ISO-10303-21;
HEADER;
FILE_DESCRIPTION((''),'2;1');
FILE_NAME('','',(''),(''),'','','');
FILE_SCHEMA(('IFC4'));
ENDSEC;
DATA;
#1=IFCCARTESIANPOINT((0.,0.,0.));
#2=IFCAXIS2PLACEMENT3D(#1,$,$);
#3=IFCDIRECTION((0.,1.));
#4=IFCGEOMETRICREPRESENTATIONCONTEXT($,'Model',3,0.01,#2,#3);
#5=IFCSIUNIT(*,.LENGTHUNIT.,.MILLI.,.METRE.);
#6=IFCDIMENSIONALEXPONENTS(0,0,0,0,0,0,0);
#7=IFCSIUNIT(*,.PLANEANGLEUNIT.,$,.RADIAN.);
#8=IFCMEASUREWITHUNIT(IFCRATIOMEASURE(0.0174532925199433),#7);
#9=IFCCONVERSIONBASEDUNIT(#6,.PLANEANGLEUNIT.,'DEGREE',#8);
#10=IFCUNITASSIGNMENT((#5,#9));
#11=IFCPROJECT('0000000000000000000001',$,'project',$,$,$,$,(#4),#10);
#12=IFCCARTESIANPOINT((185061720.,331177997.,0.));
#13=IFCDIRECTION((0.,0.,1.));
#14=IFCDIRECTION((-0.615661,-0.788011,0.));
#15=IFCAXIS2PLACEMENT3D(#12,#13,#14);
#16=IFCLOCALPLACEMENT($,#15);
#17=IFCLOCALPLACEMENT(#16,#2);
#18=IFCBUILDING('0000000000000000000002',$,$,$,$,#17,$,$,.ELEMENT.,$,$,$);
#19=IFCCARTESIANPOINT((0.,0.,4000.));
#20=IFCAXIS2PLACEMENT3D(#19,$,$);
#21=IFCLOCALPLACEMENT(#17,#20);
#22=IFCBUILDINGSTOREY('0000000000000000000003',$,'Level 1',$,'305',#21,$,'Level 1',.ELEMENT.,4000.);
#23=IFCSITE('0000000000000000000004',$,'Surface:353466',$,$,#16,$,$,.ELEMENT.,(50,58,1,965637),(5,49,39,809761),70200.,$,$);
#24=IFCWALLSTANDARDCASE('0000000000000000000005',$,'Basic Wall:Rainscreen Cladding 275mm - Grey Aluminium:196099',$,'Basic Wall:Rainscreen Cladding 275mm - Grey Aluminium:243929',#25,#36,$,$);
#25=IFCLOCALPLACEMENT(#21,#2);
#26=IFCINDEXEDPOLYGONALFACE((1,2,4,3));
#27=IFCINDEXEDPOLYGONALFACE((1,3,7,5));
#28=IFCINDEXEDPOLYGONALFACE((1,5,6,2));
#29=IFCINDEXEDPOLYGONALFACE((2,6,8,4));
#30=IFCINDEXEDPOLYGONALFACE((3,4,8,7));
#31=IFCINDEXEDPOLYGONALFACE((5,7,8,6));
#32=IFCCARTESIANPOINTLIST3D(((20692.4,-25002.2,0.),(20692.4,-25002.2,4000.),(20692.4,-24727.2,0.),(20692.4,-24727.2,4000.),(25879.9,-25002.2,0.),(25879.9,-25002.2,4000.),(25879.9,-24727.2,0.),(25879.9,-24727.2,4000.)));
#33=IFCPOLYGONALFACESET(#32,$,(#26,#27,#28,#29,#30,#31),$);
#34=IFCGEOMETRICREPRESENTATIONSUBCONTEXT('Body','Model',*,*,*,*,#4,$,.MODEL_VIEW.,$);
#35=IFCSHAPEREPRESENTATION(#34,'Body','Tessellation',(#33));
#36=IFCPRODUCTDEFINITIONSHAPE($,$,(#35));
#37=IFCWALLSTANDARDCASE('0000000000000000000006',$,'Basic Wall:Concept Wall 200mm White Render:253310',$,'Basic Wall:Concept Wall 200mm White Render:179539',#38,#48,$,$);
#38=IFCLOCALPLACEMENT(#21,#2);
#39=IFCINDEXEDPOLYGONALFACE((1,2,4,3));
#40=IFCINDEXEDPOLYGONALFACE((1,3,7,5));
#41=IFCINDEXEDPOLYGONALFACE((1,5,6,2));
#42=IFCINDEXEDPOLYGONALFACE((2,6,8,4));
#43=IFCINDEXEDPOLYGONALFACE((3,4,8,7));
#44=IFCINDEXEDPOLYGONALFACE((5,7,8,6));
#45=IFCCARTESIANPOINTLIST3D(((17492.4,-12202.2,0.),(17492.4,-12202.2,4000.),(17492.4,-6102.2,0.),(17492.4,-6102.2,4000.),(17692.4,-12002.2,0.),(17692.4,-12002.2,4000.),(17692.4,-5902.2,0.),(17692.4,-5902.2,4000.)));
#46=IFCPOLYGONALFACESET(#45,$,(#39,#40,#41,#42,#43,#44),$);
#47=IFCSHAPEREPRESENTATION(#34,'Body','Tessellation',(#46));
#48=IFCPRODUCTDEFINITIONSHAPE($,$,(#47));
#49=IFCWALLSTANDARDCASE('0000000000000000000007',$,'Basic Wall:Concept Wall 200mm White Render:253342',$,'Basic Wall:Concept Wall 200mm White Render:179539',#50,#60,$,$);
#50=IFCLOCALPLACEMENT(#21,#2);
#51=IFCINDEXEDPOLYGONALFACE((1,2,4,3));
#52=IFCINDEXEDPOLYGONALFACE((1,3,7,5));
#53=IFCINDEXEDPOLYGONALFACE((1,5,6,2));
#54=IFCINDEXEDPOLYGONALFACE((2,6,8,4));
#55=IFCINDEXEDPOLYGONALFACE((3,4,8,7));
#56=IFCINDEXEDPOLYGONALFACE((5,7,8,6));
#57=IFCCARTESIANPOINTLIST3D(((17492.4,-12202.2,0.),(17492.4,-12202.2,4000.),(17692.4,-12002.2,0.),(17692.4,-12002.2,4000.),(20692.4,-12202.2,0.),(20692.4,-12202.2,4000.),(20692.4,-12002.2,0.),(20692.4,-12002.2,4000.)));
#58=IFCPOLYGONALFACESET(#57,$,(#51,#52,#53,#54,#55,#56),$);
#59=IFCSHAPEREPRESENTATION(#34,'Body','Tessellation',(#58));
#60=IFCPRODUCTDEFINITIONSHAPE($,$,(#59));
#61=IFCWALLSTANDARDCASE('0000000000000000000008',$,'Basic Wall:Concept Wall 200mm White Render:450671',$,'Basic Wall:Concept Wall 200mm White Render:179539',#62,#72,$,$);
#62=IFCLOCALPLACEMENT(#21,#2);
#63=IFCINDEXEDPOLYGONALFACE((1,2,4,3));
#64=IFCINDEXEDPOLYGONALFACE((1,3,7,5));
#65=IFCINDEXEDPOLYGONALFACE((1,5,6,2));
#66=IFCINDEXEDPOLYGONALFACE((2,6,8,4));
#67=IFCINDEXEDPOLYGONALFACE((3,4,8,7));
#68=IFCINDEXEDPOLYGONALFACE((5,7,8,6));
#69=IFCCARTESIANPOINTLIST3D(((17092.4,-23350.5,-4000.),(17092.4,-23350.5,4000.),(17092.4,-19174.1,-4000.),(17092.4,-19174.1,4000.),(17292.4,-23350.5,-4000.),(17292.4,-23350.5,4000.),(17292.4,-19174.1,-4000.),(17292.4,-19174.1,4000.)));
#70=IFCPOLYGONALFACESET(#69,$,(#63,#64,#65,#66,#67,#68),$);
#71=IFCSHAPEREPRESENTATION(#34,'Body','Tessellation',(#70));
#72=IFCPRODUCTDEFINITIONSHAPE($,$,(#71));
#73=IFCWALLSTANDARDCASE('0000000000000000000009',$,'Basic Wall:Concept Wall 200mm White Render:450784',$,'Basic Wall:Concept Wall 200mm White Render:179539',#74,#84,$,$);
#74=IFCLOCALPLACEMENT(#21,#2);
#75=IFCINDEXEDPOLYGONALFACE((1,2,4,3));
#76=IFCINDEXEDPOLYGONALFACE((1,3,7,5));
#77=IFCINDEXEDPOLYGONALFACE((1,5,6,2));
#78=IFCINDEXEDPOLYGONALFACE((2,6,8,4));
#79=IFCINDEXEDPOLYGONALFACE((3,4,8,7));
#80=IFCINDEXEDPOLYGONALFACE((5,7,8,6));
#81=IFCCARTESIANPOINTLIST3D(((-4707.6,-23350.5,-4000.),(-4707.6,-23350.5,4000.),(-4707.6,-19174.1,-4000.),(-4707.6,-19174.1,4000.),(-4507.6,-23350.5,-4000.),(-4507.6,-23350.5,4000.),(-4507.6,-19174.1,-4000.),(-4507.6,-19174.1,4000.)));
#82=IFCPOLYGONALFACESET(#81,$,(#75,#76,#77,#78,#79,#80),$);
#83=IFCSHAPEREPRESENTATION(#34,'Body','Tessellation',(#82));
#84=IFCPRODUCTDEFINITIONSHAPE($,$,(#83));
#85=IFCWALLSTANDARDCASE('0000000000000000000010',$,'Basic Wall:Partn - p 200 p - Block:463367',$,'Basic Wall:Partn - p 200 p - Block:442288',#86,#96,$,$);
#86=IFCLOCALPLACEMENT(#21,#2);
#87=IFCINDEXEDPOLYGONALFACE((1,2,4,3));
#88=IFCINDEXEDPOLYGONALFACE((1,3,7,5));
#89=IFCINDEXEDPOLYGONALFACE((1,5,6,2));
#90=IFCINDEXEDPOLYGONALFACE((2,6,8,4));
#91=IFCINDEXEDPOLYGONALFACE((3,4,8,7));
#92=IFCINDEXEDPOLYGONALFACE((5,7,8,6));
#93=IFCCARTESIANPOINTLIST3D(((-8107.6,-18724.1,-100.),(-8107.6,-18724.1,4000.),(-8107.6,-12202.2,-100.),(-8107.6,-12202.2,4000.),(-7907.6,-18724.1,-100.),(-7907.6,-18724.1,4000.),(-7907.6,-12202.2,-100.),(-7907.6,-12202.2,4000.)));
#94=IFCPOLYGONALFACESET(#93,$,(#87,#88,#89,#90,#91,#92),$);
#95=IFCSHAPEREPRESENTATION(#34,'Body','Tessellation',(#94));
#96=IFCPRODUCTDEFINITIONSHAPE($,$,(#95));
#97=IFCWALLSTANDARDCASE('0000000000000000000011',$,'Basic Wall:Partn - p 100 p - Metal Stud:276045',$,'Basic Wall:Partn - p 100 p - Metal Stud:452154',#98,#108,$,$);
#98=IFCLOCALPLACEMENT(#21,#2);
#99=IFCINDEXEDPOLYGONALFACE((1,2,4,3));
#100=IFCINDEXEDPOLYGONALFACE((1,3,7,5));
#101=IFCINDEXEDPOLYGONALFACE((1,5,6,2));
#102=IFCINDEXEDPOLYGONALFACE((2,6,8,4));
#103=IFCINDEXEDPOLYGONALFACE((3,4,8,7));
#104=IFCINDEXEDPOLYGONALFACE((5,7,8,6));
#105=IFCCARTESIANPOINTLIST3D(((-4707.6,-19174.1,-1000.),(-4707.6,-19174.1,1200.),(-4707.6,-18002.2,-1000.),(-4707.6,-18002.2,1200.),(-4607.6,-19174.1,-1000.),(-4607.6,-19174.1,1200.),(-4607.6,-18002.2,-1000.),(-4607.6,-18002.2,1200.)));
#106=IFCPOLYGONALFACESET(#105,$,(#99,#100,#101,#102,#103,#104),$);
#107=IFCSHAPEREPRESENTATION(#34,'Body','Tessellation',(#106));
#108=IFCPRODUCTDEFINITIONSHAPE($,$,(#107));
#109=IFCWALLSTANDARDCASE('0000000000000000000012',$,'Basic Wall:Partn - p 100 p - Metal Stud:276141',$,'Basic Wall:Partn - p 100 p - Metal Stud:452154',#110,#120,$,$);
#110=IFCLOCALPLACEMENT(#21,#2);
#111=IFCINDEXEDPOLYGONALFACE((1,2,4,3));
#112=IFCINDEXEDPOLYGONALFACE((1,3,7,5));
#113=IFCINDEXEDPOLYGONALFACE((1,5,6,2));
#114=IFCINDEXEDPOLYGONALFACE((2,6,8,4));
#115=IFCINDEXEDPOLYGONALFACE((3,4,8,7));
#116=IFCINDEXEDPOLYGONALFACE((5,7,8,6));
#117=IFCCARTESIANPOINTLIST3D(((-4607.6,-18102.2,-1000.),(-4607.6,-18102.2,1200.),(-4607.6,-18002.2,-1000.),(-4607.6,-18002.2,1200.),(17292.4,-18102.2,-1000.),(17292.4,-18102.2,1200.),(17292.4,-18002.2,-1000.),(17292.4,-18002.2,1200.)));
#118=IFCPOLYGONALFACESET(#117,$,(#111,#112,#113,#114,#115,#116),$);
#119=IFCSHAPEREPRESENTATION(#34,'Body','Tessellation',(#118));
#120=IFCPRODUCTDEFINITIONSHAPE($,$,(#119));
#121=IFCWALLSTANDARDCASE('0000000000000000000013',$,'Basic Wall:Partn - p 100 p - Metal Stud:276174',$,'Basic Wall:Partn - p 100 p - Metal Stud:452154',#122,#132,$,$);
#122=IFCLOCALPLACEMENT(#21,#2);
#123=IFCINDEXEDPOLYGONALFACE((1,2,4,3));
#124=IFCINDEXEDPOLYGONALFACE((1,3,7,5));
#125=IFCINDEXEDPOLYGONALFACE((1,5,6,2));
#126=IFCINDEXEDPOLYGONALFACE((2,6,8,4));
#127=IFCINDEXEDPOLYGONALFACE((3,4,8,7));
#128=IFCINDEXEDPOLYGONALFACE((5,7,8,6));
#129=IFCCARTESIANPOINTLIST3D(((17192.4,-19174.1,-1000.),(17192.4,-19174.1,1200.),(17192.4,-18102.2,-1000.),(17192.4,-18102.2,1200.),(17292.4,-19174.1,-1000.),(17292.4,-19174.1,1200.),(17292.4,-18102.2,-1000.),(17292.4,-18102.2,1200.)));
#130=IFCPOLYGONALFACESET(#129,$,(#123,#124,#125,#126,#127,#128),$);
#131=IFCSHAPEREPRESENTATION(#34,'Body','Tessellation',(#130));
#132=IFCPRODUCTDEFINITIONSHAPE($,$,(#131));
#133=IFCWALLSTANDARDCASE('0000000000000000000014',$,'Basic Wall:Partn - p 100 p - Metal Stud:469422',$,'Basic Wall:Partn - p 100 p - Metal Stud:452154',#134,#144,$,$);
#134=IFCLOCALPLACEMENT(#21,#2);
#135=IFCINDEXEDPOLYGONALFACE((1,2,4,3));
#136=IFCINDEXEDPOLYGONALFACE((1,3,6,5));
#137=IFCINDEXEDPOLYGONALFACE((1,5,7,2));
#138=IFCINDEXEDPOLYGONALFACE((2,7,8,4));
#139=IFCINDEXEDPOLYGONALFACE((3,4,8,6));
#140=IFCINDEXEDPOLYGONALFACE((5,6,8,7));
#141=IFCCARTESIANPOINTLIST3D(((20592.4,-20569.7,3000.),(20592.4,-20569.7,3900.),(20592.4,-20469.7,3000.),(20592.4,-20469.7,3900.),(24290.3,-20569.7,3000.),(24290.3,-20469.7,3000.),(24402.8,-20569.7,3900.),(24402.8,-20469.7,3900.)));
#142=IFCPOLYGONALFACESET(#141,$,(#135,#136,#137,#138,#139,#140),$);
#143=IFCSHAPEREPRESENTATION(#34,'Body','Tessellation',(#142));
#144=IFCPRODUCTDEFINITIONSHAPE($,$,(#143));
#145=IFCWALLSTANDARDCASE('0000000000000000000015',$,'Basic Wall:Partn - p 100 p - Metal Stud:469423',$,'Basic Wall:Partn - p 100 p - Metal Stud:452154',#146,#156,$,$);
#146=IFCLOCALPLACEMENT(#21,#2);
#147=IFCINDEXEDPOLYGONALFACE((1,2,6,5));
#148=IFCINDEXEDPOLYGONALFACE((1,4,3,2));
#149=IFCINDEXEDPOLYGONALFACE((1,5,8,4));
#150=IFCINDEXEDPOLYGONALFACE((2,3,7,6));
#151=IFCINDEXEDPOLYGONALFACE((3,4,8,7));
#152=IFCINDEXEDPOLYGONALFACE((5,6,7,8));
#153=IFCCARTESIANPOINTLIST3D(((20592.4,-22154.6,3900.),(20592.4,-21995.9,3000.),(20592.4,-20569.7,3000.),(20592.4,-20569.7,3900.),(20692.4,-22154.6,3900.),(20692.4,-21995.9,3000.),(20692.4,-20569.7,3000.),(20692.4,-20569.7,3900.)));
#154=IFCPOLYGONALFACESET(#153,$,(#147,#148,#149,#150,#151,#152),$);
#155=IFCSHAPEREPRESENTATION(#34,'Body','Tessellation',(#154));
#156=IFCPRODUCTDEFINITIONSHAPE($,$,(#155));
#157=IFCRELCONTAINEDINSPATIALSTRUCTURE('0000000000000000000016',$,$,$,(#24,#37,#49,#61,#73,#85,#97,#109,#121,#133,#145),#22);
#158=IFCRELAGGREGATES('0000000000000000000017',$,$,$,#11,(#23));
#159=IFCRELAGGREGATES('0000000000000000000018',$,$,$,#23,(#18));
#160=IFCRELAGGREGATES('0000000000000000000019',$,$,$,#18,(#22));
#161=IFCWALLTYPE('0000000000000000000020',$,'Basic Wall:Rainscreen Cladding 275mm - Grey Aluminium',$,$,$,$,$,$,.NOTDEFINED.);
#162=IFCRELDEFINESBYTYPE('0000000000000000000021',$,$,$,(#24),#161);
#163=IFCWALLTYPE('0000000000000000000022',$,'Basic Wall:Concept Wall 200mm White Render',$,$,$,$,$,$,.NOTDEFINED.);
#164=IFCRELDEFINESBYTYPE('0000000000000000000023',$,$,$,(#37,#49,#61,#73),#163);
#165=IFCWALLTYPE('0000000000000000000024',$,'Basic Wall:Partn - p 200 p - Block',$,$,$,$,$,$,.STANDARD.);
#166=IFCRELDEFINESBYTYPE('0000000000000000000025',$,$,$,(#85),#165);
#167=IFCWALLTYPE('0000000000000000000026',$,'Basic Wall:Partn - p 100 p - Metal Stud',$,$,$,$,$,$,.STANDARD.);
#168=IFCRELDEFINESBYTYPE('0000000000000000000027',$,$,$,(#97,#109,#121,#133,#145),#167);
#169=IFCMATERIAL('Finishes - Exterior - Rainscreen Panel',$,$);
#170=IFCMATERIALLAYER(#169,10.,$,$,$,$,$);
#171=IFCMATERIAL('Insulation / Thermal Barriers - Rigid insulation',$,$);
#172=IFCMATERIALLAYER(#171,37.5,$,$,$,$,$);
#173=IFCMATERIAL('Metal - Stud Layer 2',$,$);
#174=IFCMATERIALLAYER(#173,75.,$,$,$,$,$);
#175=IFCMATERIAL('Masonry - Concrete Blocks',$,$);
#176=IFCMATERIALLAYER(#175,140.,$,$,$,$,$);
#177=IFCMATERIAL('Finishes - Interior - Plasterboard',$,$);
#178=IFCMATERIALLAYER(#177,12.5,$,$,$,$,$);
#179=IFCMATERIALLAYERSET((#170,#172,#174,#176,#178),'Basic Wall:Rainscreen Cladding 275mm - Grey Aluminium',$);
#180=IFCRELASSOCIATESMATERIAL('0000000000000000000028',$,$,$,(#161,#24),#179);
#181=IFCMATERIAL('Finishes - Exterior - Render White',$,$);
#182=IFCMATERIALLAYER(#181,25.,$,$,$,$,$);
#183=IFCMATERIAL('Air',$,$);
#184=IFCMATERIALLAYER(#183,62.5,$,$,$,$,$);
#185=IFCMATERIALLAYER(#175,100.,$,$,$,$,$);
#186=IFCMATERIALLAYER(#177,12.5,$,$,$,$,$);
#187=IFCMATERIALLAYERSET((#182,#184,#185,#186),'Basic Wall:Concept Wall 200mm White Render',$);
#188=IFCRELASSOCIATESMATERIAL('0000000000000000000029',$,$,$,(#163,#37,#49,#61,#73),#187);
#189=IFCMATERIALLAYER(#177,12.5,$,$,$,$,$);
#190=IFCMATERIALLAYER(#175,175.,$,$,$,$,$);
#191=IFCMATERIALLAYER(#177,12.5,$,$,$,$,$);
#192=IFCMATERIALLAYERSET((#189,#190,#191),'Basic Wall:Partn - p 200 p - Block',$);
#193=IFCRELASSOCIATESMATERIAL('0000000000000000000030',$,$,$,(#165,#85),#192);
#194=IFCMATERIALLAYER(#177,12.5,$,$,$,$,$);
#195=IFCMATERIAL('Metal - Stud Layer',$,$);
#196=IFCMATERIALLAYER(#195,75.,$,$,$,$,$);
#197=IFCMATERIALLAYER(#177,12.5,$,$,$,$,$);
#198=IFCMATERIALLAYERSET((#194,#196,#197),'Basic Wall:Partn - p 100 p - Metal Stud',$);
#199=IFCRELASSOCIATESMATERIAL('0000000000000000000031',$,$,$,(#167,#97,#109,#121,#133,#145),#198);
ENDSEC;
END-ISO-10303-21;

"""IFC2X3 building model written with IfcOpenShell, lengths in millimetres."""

from ifc_helpers import new_model, entity, si_unit, converted_unit, direction, frame, frame_2d, origin, place, context, subcontext, project, spatial, polyline, rectangle, outline, extrude, clip, halfspace, material, layer, layer_set, layer_usage, type_object, element, save


model = new_model("IFC2X3")

# Units and contexts
model_context = context("Model", 3, precision=0.01, world=origin(), true_north=direction((0.0, 1.0)))
body_context = subcontext(model_context, "Body", "Model", "MODEL_VIEW")
ifc_project = project(units=[si_unit("LENGTHUNIT", "METRE", prefix="MILLI"), converted_unit("PLANEANGLEUNIT", "DEGREE", entity("IfcRatioMeasure", 0.0174532925199433), si_unit("PLANEANGLEUNIT", "RADIAN"), dimensions=[0, 0, 0, 0, 0, 0, 0])], contexts=[model_context])

# Site, building, storey
site_placement = place(None, frame((185061720.0, 331177997.0, 0.0), z_axis=(0.0, 0.0, 1.0), x_axis=(-0.615661, -0.788011, 0.0)))
site = spatial("IfcSite", under=ifc_project, at=site_placement, Name="Surface:353466", CompositionType="ELEMENT", RefLatitude=(50, 58, 1, 965637), RefLongitude=(5, 49, 39, 809761), RefElevation=70200.0)
building_placement = place(site_placement, origin())
building = spatial("IfcBuilding", under=site, at=building_placement, CompositionType="ELEMENT")
storey_placement = place(building_placement, frame((0.0, 0.0, 4000.0)))
storey = spatial("IfcBuildingStorey", under=building, at=storey_placement, Name="Level 1", ObjectType="305", LongName="Level 1", CompositionType="ELEMENT", Elevation=4000.0)

# Walls
ifc_material_1 = material(Name="Finishes - Exterior - Rainscreen Panel")
ifc_layer_1 = layer(ifc_material_1, 10.0)
ifc_material_2 = material(Name="Insulation / Thermal Barriers - Rigid insulation")
ifc_layer_2 = layer(ifc_material_2, 37.5)
ifc_material_3 = material(Name="Metal - Stud Layer 2")
ifc_layer_3 = layer(ifc_material_3, 75.0)
ifc_material_4 = material(Name="Masonry - Concrete Blocks")
ifc_layer_4 = layer(ifc_material_4, 140.0)
ifc_material_5 = material(Name="Finishes - Interior - Plasterboard")
ifc_layer_5 = layer(ifc_material_5, 12.5)
ifc_layer_set_1 = layer_set([ifc_layer_1, ifc_layer_2, ifc_layer_3, ifc_layer_4, ifc_layer_5], Name="Basic Wall:Rainscreen Cladding 275mm - Grey Aluminium")
ifc_layer_usage_1 = layer_usage(ifc_layer_set_1, "AXIS2", "POSITIVE", -137.5)
wall_type_1 = type_object("IfcWallType", Name="Basic Wall:Rainscreen Cladding 275mm - Grey Aluminium", PredefinedType="NOTDEFINED", material=ifc_layer_set_1)
wall_1_placement = place(storey_placement, frame((20692.4, -24864.7, 0.0)))
element("IfcWallStandardCase", 1, at=wall_1_placement, inside=storey, type_object=wall_type_1, material=ifc_layer_usage_1, Name="Basic Wall:Rainscreen Cladding 275mm - Grey Aluminium:196099", ObjectType="Basic Wall:Rainscreen Cladding 275mm - Grey Aluminium:243929", context=body_context, shape_type="Clipping", body=[
    clip(extrude(rectangle(XDim=5187.5, YDim=275.0, at=frame_2d((2593.8, 0.0), x_axis=(-1.0, 0.0))), origin(), (0.0, 0.0, 1.0), 4000.0), halfspace(frame((0.0, 0.0, -4000.0)), True)),
])
ifc_material_6 = material(Name="Finishes - Exterior - Render White")
ifc_layer_6 = layer(ifc_material_6, 25.0)
ifc_material_7 = material(Name="Air")
ifc_layer_7 = layer(ifc_material_7, 62.5)
ifc_layer_8 = layer(ifc_material_4, 100.0)
ifc_layer_9 = layer(ifc_material_5, 12.5)
ifc_layer_set_2 = layer_set([ifc_layer_6, ifc_layer_7, ifc_layer_8, ifc_layer_9], Name="Basic Wall:Concept Wall 200mm White Render")
ifc_layer_usage_2 = layer_usage(ifc_layer_set_2, "AXIS2", "NEGATIVE", 100.0)
wall_type_2 = type_object("IfcWallType", Name="Basic Wall:Concept Wall 200mm White Render", PredefinedType="NOTDEFINED", material=ifc_layer_set_2)
wall_2_placement = place(storey_placement, frame((17592.4, -5902.2, 0.0), z_axis=(0.0, 0.0, 1.0), x_axis=(0.0, -1.0, 0.0)))
element("IfcWallStandardCase", 2, at=wall_2_placement, inside=storey, type_object=wall_type_2, material=ifc_layer_usage_2, Name="Basic Wall:Concept Wall 200mm White Render:253310", ObjectType="Basic Wall:Concept Wall 200mm White Render:179539", context=body_context, shape_type="Clipping", body=[
    clip(extrude(outline(polyline([(6300.0, -100.0), (6100.0, 100.0), (0.0, 100.0), (200.0, -100.0), (6300.0, -100.0)])), origin(), (0.0, 0.0, 1.0), 4000.0), halfspace(frame((0.0, 0.0, -4000.0)), True)),
])
ifc_layer_usage_3 = layer_usage(ifc_layer_set_2, "AXIS2", "NEGATIVE", 100.0)
wall_3_placement = place(storey_placement, frame((17492.4, -12102.2, 0.0)))
element("IfcWallStandardCase", 3, at=wall_3_placement, inside=storey, type_object=wall_type_2, material=ifc_layer_usage_3, Name="Basic Wall:Concept Wall 200mm White Render:253342", ObjectType="Basic Wall:Concept Wall 200mm White Render:179539", context=body_context, shape_type="Clipping", body=[
    clip(extrude(outline(polyline([(0.0, -100.0), (3200.0, -100.0), (3200.0, 100.0), (200.0, 100.0), (0.0, -100.0)])), origin(), (0.0, 0.0, 1.0), 4000.0), halfspace(frame((0.0, 0.0, -4000.0)), True)),
])
ifc_layer_usage_4 = layer_usage(ifc_layer_set_2, "AXIS2", "NEGATIVE", 100.0)
wall_4_placement = place(storey_placement, frame((17192.4, -23350.5, -4000.0), z_axis=(0.0, 0.0, 1.0), x_axis=(0.0, 1.0, 0.0)))
element("IfcWallStandardCase", 4, at=wall_4_placement, inside=storey, type_object=wall_type_2, material=ifc_layer_usage_4, Name="Basic Wall:Concept Wall 200mm White Render:450671", ObjectType="Basic Wall:Concept Wall 200mm White Render:179539", context=body_context, shape_type="Clipping", body=[
    clip(extrude(rectangle(XDim=4176.4, YDim=200.0, at=frame_2d((2088.2, 0.0), x_axis=(-1.0, 0.0))), origin(), (0.0, 0.0, 1.0), 8000.0), halfspace(frame((0.0, 0.0, -4000.0)), True)),
])
ifc_layer_usage_5 = layer_usage(ifc_layer_set_2, "AXIS2", "POSITIVE", -100.0)
wall_5_placement = place(storey_placement, frame((-4607.6, -23350.5, -4000.0), z_axis=(0.0, 0.0, 1.0), x_axis=(0.0, 1.0, 0.0)))
element("IfcWallStandardCase", 5, at=wall_5_placement, inside=storey, type_object=wall_type_2, material=ifc_layer_usage_5, Name="Basic Wall:Concept Wall 200mm White Render:450784", ObjectType="Basic Wall:Concept Wall 200mm White Render:179539", context=body_context, shape_type="Clipping", body=[
    clip(extrude(rectangle(XDim=4176.4, YDim=200.0, at=frame_2d((2088.2, 0.0), x_axis=(-1.0, 0.0))), origin(), (0.0, 0.0, 1.0), 8000.0), halfspace(frame((0.0, 0.0, -4000.0)), True)),
])
ifc_layer_10 = layer(ifc_material_5, 12.5)
ifc_layer_11 = layer(ifc_material_4, 175.0)
ifc_layer_12 = layer(ifc_material_5, 12.5)
ifc_layer_set_3 = layer_set([ifc_layer_10, ifc_layer_11, ifc_layer_12], Name="Basic Wall:Partn - p 200 p - Block")
ifc_layer_usage_6 = layer_usage(ifc_layer_set_3, "AXIS2", "NEGATIVE", 100.0)
wall_type_3 = type_object("IfcWallType", Name="Basic Wall:Partn - p 200 p - Block", PredefinedType="STANDARD", material=ifc_layer_set_3)
wall_6_placement = place(storey_placement, frame((-8007.6, -18724.1, -100.0), z_axis=(0.0, 0.0, 1.0), x_axis=(0.0, 1.0, 0.0)))
element("IfcWallStandardCase", 6, at=wall_6_placement, inside=storey, type_object=wall_type_3, material=ifc_layer_usage_6, Name="Basic Wall:Partn - p 200 p - Block:463367", ObjectType="Basic Wall:Partn - p 200 p - Block:442288", context=body_context, shape_type="Clipping", body=[
    clip(extrude(rectangle(XDim=6521.9, YDim=200.0, at=frame_2d((3261.0, 0.0), x_axis=(-1.0, 0.0))), origin(), (0.0, 0.0, 1.0), 4100.0), halfspace(frame((0.0, 0.0, -100.0)), True)),
])
ifc_layer_13 = layer(ifc_material_5, 12.5)
ifc_material_8 = material(Name="Metal - Stud Layer")
ifc_layer_14 = layer(ifc_material_8, 75.0)
ifc_layer_15 = layer(ifc_material_5, 12.5)
ifc_layer_set_4 = layer_set([ifc_layer_13, ifc_layer_14, ifc_layer_15], Name="Basic Wall:Partn - p 100 p - Metal Stud")
ifc_layer_usage_7 = layer_usage(ifc_layer_set_4, "AXIS2", "POSITIVE", -50.0)
wall_type_4 = type_object("IfcWallType", Name="Basic Wall:Partn - p 100 p - Metal Stud", PredefinedType="STANDARD", material=ifc_layer_set_4)
wall_7_placement = place(storey_placement, frame((-4657.6, -19174.1, -1000.0), z_axis=(0.0, 0.0, 1.0), x_axis=(0.0, 1.0, 0.0)))
element("IfcWallStandardCase", 7, at=wall_7_placement, inside=storey, type_object=wall_type_4, material=ifc_layer_usage_7, Name="Basic Wall:Partn - p 100 p - Metal Stud:276045", ObjectType="Basic Wall:Partn - p 100 p - Metal Stud:452154", context=body_context, shape_type="SweptSolid", body=[
    extrude(rectangle(XDim=1171.9, YDim=100.0, at=frame_2d((586.0, 0.0), x_axis=(-1.0, 0.0))), origin(), (0.0, 0.0, 1.0), 2200.0),
])
ifc_layer_usage_8 = layer_usage(ifc_layer_set_4, "AXIS2", "POSITIVE", -50.0)
wall_8_placement = place(storey_placement, frame((-4607.6, -18052.2, -1000.0)))
element("IfcWallStandardCase", 8, at=wall_8_placement, inside=storey, type_object=wall_type_4, material=ifc_layer_usage_8, Name="Basic Wall:Partn - p 100 p - Metal Stud:276141", ObjectType="Basic Wall:Partn - p 100 p - Metal Stud:452154", context=body_context, shape_type="SweptSolid", body=[
    extrude(rectangle(XDim=21900.0, YDim=100.0, at=frame_2d((10950.0, 0.0), x_axis=(-1.0, 0.0))), origin(), (0.0, 0.0, 1.0), 2200.0),
])
ifc_layer_usage_9 = layer_usage(ifc_layer_set_4, "AXIS2", "POSITIVE", -50.0)
wall_9_placement = place(storey_placement, frame((17242.4, -18102.2, -1000.0), z_axis=(0.0, 0.0, 1.0), x_axis=(0.0, -1.0, 0.0)))
element("IfcWallStandardCase", 9, at=wall_9_placement, inside=storey, type_object=wall_type_4, material=ifc_layer_usage_9, Name="Basic Wall:Partn - p 100 p - Metal Stud:276174", ObjectType="Basic Wall:Partn - p 100 p - Metal Stud:452154", context=body_context, shape_type="SweptSolid", body=[
    extrude(rectangle(XDim=1071.9, YDim=100.0, at=frame_2d((536.0, 0.0), x_axis=(-1.0, 0.0))), origin(), (0.0, 0.0, 1.0), 2200.0),
])
ifc_layer_usage_10 = layer_usage(ifc_layer_set_4, "AXIS2", "POSITIVE", -50.0)
wall_10_placement = place(storey_placement, frame((24402.8, -20519.7, 3000.0), z_axis=(0.0, 0.0, 1.0), x_axis=(-1.0, 0.0, 0.0)))
element("IfcWallStandardCase", 10, at=wall_10_placement, inside=storey, type_object=wall_type_4, material=ifc_layer_usage_10, Name="Basic Wall:Partn - p 100 p - Metal Stud:469422", ObjectType="Basic Wall:Partn - p 100 p - Metal Stud:452154", context=body_context, shape_type="Clipping", body=[
    clip(extrude(rectangle(XDim=3810.4, YDim=100.0, at=frame_2d((1905.2, 0.0), x_axis=(-1.0, 0.0))), origin(), (0.0, 0.0, 1.0), 900.0), halfspace(frame((112.5, -50.0, 0.0), z_axis=(-0.992278, 0.0, -0.124035), x_axis=(0.0, 1.0, 0.0)), False)),
])
ifc_layer_usage_11 = layer_usage(ifc_layer_set_4, "AXIS2", "POSITIVE", -50.0)
wall_11_placement = place(storey_placement, frame((20642.4, -20569.7, 3000.0), z_axis=(0.0, 0.0, 1.0), x_axis=(0.0, -1.0, 0.0)))
element("IfcWallStandardCase", 11, at=wall_11_placement, inside=storey, type_object=wall_type_4, material=ifc_layer_usage_11, Name="Basic Wall:Partn - p 100 p - Metal Stud:469423", ObjectType="Basic Wall:Partn - p 100 p - Metal Stud:452154", context=body_context, shape_type="Clipping", body=[
    clip(extrude(rectangle(XDim=1584.9, YDim=100.0, at=frame_2d((792.4, 0.0), x_axis=(-1.0, 0.0))), origin(), (0.0, 0.0, 1.0), 900.0), halfspace(frame((1584.9, -50.0, 900.0), z_axis=(0.984808, 0.0, -0.173648), x_axis=(0.0, 1.0, 0.0)), False)),
])

save(model, "model.ifc")
